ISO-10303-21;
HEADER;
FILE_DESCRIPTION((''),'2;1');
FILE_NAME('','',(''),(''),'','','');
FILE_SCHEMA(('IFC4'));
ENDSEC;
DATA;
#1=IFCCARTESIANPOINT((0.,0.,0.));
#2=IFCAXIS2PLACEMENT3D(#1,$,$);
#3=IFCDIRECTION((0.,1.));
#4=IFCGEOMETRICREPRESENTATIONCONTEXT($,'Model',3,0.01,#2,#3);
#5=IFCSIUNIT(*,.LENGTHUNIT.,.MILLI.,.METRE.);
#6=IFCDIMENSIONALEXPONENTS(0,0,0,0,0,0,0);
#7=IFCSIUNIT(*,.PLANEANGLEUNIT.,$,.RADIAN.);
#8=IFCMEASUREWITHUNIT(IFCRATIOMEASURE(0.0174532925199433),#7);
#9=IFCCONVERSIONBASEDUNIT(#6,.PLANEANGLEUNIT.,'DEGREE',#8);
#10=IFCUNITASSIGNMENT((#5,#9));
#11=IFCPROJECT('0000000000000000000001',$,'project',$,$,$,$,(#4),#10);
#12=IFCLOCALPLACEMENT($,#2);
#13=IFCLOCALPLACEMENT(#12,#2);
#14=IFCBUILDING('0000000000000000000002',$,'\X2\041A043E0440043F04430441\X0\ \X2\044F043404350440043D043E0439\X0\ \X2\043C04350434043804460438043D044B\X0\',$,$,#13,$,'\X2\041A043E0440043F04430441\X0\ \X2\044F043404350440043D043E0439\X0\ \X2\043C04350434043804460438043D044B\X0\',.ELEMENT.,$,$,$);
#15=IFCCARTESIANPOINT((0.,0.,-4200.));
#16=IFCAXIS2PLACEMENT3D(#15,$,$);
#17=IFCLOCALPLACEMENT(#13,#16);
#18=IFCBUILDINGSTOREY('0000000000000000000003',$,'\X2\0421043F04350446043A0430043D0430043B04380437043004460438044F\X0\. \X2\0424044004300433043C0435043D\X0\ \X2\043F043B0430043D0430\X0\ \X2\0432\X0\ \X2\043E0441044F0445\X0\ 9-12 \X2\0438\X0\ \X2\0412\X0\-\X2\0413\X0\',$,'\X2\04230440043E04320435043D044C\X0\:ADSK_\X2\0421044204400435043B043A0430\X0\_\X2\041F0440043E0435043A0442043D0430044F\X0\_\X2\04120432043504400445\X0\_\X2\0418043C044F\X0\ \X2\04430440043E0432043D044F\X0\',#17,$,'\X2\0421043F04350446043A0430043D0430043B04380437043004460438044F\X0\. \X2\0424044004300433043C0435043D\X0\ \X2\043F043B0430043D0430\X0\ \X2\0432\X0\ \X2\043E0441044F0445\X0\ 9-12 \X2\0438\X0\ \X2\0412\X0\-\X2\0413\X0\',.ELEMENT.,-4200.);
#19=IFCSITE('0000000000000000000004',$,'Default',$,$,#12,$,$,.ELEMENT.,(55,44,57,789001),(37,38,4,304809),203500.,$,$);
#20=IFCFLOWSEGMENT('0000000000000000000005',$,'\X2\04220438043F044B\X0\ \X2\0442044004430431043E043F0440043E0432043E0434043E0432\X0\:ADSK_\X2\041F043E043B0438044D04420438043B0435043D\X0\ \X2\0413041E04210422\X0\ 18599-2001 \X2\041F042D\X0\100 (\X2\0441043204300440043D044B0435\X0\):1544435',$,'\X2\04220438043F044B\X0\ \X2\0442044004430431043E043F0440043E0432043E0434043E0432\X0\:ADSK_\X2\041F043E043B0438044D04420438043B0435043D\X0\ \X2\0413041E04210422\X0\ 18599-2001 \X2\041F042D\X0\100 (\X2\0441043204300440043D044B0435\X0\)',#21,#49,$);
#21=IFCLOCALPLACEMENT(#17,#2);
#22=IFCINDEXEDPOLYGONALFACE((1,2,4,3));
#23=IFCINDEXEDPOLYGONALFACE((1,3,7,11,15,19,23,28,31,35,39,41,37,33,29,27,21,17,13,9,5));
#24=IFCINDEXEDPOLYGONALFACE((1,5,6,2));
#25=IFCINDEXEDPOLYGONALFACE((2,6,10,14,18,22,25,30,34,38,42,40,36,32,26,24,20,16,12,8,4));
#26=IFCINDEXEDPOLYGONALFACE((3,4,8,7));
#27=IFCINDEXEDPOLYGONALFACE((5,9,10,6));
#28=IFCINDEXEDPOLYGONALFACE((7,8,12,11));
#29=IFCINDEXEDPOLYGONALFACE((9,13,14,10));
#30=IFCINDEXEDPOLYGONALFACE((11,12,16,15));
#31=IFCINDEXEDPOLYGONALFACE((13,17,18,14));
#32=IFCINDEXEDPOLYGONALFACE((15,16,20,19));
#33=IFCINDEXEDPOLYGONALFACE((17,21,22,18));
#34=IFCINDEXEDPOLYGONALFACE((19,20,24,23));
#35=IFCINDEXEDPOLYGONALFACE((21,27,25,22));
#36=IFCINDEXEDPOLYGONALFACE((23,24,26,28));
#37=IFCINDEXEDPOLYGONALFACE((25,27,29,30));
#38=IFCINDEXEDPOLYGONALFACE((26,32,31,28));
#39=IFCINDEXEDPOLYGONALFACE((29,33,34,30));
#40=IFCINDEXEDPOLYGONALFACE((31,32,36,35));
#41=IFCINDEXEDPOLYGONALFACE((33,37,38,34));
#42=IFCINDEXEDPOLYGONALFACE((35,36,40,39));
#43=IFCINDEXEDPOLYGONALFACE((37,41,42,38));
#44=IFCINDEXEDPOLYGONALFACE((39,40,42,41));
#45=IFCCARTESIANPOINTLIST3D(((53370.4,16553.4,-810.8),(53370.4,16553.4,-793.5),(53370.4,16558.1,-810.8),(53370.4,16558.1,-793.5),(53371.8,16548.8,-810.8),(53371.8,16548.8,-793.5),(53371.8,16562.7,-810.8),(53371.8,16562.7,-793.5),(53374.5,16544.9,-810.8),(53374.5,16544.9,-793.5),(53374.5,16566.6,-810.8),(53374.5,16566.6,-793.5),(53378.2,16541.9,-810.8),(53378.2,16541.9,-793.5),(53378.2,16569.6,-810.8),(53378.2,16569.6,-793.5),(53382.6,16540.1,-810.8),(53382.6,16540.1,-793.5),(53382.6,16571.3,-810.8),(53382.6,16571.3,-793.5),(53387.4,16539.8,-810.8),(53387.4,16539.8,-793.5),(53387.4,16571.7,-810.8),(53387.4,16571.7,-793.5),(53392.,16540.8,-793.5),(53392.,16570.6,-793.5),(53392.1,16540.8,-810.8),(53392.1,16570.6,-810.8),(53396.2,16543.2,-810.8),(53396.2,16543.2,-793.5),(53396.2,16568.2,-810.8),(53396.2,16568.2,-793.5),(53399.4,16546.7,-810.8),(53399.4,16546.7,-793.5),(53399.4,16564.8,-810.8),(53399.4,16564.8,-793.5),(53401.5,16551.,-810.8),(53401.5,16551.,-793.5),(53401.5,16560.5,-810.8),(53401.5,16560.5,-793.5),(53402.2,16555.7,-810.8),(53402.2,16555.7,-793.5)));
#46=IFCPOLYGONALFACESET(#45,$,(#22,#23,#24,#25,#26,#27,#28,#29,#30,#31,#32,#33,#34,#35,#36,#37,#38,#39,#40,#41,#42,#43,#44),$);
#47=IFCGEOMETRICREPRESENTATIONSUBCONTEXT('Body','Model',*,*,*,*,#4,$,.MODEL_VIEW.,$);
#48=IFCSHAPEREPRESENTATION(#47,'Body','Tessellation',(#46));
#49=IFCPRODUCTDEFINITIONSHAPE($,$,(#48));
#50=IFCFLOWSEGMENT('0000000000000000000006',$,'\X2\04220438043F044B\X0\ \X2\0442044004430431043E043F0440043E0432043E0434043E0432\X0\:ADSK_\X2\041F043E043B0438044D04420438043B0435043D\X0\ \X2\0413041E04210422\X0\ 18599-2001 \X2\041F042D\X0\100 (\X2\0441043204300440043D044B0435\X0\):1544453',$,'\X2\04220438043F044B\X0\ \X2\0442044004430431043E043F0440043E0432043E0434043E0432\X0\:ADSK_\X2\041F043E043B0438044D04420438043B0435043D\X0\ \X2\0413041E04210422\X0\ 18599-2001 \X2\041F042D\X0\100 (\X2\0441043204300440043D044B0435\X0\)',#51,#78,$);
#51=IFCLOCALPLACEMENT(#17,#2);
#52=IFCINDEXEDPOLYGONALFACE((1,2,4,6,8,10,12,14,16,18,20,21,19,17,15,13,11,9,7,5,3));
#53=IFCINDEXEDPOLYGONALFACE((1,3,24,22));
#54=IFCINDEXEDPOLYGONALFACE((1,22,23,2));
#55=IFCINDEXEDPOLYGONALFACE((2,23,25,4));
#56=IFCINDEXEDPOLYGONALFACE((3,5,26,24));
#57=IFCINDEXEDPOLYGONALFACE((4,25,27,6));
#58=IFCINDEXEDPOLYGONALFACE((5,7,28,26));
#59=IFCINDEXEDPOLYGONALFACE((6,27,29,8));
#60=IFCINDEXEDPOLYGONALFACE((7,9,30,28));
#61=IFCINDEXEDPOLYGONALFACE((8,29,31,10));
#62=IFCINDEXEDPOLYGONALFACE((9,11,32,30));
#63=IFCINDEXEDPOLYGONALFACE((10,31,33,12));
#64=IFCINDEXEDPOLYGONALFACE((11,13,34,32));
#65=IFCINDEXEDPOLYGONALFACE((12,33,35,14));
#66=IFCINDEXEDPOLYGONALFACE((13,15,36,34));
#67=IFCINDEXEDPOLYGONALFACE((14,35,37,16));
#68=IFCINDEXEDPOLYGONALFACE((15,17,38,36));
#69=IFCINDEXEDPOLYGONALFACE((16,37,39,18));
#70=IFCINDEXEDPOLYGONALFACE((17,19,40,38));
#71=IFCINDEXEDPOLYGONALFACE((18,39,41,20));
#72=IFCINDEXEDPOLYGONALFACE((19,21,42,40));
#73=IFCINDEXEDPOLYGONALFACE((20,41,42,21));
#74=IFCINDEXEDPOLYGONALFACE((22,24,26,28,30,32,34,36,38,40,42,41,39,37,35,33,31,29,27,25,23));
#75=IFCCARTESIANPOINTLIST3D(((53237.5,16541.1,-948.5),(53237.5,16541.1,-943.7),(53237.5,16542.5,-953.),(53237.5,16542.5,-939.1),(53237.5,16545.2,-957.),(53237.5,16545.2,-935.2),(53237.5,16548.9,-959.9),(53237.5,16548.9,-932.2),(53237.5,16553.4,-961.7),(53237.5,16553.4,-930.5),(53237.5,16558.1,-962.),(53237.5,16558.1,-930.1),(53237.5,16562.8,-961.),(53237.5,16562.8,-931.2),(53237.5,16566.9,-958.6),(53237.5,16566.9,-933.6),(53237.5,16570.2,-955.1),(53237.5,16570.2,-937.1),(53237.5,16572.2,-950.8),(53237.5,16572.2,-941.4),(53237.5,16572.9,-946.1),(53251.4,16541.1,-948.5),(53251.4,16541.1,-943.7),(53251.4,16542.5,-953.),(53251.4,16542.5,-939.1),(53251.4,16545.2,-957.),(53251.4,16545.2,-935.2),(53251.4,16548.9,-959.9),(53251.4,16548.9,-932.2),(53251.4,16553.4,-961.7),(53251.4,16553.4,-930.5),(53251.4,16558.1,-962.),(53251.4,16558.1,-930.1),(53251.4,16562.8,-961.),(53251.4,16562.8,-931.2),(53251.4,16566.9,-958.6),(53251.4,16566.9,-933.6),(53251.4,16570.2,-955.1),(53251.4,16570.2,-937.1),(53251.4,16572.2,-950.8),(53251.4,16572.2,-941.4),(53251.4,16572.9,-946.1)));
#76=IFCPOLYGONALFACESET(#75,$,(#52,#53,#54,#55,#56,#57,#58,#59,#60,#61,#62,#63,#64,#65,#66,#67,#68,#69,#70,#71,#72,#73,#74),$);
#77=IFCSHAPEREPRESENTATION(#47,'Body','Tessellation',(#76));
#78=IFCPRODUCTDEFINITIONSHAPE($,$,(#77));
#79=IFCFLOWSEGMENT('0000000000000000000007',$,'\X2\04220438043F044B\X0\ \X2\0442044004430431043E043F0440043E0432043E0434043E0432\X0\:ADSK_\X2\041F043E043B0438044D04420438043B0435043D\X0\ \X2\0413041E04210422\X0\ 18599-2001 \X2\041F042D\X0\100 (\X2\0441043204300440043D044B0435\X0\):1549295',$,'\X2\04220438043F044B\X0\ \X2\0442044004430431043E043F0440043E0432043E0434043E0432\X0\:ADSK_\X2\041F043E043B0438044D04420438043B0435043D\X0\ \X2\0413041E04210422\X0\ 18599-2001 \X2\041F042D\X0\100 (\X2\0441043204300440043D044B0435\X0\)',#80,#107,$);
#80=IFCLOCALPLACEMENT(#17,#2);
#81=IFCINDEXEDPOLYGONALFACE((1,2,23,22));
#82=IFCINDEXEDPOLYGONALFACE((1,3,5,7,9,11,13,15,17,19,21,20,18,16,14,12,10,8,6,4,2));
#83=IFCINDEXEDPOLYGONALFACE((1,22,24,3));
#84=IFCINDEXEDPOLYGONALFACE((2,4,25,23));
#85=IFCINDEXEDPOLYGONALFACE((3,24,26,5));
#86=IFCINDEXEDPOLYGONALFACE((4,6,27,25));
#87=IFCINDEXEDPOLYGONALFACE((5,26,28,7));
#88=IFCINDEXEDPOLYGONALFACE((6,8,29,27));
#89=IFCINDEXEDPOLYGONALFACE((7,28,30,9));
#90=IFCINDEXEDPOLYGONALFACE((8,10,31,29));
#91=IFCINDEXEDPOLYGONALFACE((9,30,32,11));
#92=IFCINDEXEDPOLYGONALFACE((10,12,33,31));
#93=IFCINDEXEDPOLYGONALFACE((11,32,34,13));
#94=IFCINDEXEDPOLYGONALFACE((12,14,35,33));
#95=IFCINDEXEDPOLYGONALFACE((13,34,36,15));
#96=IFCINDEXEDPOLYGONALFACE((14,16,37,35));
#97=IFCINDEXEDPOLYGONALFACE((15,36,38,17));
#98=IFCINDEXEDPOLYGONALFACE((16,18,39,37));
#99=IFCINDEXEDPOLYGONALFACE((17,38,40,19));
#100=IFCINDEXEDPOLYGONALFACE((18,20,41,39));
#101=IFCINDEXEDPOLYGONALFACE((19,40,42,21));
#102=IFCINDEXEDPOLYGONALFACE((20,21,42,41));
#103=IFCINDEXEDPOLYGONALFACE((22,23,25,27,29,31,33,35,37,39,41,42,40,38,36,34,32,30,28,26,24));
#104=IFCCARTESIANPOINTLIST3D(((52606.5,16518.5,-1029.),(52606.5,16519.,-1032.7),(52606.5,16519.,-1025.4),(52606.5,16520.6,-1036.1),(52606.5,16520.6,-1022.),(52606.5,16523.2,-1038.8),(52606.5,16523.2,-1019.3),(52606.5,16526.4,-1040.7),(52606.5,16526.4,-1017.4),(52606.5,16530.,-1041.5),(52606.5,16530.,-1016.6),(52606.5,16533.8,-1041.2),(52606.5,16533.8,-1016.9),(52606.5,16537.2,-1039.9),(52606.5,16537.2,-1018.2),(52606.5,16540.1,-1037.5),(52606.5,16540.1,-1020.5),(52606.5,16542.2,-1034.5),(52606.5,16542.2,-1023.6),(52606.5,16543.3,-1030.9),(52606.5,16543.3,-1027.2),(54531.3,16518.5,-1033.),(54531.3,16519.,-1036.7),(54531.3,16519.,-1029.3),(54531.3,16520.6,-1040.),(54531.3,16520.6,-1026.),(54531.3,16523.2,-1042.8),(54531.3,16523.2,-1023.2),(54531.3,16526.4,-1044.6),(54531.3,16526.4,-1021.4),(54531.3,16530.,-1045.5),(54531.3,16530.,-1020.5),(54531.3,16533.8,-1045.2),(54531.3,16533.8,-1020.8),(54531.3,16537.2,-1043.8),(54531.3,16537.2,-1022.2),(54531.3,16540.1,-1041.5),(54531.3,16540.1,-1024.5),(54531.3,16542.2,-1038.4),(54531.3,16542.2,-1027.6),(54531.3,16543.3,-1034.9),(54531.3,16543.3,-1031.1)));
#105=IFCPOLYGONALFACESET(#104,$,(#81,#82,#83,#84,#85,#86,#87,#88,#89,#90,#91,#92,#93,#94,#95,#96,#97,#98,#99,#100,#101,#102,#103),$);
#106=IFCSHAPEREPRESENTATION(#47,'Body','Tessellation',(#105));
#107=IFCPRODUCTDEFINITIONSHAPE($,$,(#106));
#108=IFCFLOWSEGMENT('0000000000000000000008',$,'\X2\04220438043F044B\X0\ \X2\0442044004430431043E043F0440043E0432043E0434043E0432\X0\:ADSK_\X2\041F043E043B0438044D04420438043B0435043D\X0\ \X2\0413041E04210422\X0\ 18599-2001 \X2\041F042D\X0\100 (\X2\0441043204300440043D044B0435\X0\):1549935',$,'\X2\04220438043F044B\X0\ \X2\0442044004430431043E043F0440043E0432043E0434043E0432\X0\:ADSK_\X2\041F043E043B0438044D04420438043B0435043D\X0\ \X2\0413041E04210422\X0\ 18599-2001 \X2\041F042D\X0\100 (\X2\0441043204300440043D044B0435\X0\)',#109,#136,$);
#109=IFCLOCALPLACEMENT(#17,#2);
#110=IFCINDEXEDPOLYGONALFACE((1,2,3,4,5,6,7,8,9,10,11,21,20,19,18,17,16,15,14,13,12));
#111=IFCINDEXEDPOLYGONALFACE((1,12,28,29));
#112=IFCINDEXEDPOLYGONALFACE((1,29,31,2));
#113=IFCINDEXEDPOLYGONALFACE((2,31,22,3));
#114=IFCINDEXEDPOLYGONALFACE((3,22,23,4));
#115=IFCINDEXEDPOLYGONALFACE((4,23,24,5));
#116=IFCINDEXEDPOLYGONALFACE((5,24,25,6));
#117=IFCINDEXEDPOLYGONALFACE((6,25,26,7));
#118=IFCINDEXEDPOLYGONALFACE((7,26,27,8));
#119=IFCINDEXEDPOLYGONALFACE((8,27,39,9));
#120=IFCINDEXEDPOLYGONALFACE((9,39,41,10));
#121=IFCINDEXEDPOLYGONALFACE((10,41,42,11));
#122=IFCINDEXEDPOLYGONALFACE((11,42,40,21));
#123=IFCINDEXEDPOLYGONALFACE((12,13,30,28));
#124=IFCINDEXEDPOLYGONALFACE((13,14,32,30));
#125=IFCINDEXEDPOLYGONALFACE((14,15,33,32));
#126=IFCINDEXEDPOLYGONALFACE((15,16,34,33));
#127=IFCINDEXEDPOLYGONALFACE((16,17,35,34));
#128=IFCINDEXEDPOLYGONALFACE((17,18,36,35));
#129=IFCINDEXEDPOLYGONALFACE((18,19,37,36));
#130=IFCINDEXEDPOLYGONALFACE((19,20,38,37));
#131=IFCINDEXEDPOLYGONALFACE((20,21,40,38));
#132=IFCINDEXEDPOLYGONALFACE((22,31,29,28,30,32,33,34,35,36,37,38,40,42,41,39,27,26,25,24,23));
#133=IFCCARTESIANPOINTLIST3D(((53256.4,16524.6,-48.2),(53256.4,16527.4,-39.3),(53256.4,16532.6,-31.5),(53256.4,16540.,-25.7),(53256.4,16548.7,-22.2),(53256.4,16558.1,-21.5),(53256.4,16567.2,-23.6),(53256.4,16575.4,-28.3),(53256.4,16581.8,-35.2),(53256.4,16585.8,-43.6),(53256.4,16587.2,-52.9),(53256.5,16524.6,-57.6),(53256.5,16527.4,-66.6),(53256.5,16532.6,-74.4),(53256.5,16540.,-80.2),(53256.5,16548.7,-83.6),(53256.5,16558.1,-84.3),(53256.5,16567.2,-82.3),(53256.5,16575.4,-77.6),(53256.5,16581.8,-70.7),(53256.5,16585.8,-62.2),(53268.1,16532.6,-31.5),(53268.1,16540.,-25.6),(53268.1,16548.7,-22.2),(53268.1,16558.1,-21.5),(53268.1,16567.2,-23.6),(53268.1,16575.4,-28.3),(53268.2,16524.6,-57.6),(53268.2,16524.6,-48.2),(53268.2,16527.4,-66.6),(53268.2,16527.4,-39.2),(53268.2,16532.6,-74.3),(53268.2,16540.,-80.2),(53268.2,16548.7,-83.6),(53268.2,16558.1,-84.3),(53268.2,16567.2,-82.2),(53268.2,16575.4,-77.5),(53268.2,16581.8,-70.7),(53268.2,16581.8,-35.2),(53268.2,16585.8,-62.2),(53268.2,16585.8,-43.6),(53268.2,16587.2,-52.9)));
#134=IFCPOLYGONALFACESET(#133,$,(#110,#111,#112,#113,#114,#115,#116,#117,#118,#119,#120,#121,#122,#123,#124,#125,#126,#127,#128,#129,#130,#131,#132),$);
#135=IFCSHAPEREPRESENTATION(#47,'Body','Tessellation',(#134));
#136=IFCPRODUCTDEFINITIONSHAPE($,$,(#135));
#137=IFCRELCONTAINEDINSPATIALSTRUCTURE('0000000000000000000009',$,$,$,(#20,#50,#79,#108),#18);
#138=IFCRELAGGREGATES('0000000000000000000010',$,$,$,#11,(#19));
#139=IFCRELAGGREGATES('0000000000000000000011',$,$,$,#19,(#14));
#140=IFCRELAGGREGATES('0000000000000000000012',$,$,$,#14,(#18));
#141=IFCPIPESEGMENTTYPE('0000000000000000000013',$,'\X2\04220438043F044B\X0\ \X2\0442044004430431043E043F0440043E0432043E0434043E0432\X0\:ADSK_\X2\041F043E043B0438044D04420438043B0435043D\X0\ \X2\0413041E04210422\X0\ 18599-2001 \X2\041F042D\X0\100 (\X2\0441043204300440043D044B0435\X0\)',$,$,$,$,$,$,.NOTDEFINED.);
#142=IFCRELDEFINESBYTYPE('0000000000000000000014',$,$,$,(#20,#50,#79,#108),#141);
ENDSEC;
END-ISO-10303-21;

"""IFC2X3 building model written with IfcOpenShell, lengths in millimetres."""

from ifc_helpers import new_model, entity, si_unit, converted_unit, direction, frame, origin, origin_2d_with_axis, place, context, subcontext, project, spatial, circle, extrude, type_object, element, save


model = new_model("IFC2X3")

# Units and contexts
model_context = context("Model", 3, precision=0.01, world=origin(), true_north=direction((0.0, 1.0)))
body_context = subcontext(model_context, "Body", "Model", "MODEL_VIEW")
ifc_project = project(units=[si_unit("LENGTHUNIT", "METRE", prefix="MILLI"), converted_unit("PLANEANGLEUNIT", "DEGREE", entity("IfcRatioMeasure", 0.0174532925199433), si_unit("PLANEANGLEUNIT", "RADIAN"), dimensions=[0, 0, 0, 0, 0, 0, 0])], contexts=[model_context])

# Site, building, storey
site_placement = place(None, origin())
site = spatial("IfcSite", under=ifc_project, at=site_placement, Name="Default", CompositionType="ELEMENT", RefLatitude=(55, 44, 57, 789001), RefLongitude=(37, 38, 4, 304809), RefElevation=203500.0)
building_placement = place(site_placement, origin())
building = spatial("IfcBuilding", under=site, at=building_placement, Name="Корпус ядерной медицины", LongName="Корпус ядерной медицины", CompositionType="ELEMENT")
storey_placement = place(building_placement, frame((0.0, 0.0, -4200.0)))
storey = spatial("IfcBuildingStorey", under=building, at=storey_placement, Name="Спецканализация. Фрагмен плана в осях 9-12 и В-Г", ObjectType="Уровень:ADSK_Стрелка_Проектная_Вверх_Имя уровня", LongName="Спецканализация. Фрагмен плана в осях 9-12 и В-Г", CompositionType="ELEMENT", Elevation=-4200.0)

# Flow segments
pipe_segment_type = type_object("IfcPipeSegmentType", Name="Типы трубопроводов:ADSK_Полиэтилен ГОСТ 18599-2001 ПЭ100 (сварные)", PredefinedType="NOTDEFINED")
flow_segment_1_placement = place(storey_placement, frame((53368.6, 16538.1, -810.8)))
element("IfcFlowSegment", 1, at=flow_segment_1_placement, inside=storey, type_object=pipe_segment_type, Name="Типы трубопроводов:ADSK_Полиэтилен ГОСТ 18599-2001 ПЭ100 (сварные):1544435", ObjectType="Типы трубопроводов:ADSK_Полиэтилен ГОСТ 18599-2001 ПЭ100 (сварные)", context=body_context, shape_type="SweptSolid", body=[
    extrude(circle(Radius=16.0, at=origin_2d_with_axis()), frame((17.6, 17.6, 0.0), z_axis=(-0.001249, 0.0, 0.999999), x_axis=(0.999999, 0.0, 0.001249)), (0.0, 0.0, 1.0), 17.3),
])
flow_segment_2_placement = place(storey_placement, frame((53237.5, 16539.3, -963.7)))
element("IfcFlowSegment", 2, at=flow_segment_2_placement, inside=storey, type_object=pipe_segment_type, Name="Типы трубопроводов:ADSK_Полиэтилен ГОСТ 18599-2001 ПЭ100 (сварные):1544453", ObjectType="Типы трубопроводов:ADSK_Полиэтилен ГОСТ 18599-2001 ПЭ100 (сварные)", context=body_context, shape_type="SweptSolid", body=[
    extrude(circle(Radius=16.0, at=origin_2d_with_axis()), frame((0.0, 17.6, 17.6), z_axis=(1.0, 0.0, 0.000899), x_axis=(0.0, 1.0, 0.0)), (0.0, 0.0, 1.0), 13.9),
])
flow_segment_3_placement = place(storey_placement, frame((52606.5, 16516.9, -1047.1)))
element("IfcFlowSegment", 3, at=flow_segment_3_placement, inside=storey, type_object=pipe_segment_type, Name="Типы трубопроводов:ADSK_Полиэтилен ГОСТ 18599-2001 ПЭ100 (сварные):1549295", ObjectType="Типы трубопроводов:ADSK_Полиэтилен ГОСТ 18599-2001 ПЭ100 (сварные)", context=body_context, shape_type="SweptSolid", body=[
    extrude(circle(Radius=12.5, at=origin_2d_with_axis()), frame((1924.8, 14.1, 14.1), z_axis=(-0.999998, 0.0, 0.002059), x_axis=(0.0, -1.0, 0.0)), (0.0, 0.0, 1.0), 1924.8),
])
flow_segment_4_placement = place(storey_placement, frame((53256.4, 16522.6, -86.0)))
element("IfcFlowSegment", 4, at=flow_segment_4_placement, inside=storey, type_object=pipe_segment_type, Name="Типы трубопроводов:ADSK_Полиэтилен ГОСТ 18599-2001 ПЭ100 (сварные):1549935", ObjectType="Типы трубопроводов:ADSK_Полиэтилен ГОСТ 18599-2001 ПЭ100 (сварные)", context=body_context, shape_type="SweptSolid", body=[
    extrude(circle(Radius=31.5, at=origin_2d_with_axis()), frame((0.1, 33.1, 33.1), z_axis=(0.999998, 0.0, 0.001821), x_axis=(0.0, 1.0, 0.0)), (0.0, 0.0, 1.0), 11.7),
])

save(model, "model.ifc")
